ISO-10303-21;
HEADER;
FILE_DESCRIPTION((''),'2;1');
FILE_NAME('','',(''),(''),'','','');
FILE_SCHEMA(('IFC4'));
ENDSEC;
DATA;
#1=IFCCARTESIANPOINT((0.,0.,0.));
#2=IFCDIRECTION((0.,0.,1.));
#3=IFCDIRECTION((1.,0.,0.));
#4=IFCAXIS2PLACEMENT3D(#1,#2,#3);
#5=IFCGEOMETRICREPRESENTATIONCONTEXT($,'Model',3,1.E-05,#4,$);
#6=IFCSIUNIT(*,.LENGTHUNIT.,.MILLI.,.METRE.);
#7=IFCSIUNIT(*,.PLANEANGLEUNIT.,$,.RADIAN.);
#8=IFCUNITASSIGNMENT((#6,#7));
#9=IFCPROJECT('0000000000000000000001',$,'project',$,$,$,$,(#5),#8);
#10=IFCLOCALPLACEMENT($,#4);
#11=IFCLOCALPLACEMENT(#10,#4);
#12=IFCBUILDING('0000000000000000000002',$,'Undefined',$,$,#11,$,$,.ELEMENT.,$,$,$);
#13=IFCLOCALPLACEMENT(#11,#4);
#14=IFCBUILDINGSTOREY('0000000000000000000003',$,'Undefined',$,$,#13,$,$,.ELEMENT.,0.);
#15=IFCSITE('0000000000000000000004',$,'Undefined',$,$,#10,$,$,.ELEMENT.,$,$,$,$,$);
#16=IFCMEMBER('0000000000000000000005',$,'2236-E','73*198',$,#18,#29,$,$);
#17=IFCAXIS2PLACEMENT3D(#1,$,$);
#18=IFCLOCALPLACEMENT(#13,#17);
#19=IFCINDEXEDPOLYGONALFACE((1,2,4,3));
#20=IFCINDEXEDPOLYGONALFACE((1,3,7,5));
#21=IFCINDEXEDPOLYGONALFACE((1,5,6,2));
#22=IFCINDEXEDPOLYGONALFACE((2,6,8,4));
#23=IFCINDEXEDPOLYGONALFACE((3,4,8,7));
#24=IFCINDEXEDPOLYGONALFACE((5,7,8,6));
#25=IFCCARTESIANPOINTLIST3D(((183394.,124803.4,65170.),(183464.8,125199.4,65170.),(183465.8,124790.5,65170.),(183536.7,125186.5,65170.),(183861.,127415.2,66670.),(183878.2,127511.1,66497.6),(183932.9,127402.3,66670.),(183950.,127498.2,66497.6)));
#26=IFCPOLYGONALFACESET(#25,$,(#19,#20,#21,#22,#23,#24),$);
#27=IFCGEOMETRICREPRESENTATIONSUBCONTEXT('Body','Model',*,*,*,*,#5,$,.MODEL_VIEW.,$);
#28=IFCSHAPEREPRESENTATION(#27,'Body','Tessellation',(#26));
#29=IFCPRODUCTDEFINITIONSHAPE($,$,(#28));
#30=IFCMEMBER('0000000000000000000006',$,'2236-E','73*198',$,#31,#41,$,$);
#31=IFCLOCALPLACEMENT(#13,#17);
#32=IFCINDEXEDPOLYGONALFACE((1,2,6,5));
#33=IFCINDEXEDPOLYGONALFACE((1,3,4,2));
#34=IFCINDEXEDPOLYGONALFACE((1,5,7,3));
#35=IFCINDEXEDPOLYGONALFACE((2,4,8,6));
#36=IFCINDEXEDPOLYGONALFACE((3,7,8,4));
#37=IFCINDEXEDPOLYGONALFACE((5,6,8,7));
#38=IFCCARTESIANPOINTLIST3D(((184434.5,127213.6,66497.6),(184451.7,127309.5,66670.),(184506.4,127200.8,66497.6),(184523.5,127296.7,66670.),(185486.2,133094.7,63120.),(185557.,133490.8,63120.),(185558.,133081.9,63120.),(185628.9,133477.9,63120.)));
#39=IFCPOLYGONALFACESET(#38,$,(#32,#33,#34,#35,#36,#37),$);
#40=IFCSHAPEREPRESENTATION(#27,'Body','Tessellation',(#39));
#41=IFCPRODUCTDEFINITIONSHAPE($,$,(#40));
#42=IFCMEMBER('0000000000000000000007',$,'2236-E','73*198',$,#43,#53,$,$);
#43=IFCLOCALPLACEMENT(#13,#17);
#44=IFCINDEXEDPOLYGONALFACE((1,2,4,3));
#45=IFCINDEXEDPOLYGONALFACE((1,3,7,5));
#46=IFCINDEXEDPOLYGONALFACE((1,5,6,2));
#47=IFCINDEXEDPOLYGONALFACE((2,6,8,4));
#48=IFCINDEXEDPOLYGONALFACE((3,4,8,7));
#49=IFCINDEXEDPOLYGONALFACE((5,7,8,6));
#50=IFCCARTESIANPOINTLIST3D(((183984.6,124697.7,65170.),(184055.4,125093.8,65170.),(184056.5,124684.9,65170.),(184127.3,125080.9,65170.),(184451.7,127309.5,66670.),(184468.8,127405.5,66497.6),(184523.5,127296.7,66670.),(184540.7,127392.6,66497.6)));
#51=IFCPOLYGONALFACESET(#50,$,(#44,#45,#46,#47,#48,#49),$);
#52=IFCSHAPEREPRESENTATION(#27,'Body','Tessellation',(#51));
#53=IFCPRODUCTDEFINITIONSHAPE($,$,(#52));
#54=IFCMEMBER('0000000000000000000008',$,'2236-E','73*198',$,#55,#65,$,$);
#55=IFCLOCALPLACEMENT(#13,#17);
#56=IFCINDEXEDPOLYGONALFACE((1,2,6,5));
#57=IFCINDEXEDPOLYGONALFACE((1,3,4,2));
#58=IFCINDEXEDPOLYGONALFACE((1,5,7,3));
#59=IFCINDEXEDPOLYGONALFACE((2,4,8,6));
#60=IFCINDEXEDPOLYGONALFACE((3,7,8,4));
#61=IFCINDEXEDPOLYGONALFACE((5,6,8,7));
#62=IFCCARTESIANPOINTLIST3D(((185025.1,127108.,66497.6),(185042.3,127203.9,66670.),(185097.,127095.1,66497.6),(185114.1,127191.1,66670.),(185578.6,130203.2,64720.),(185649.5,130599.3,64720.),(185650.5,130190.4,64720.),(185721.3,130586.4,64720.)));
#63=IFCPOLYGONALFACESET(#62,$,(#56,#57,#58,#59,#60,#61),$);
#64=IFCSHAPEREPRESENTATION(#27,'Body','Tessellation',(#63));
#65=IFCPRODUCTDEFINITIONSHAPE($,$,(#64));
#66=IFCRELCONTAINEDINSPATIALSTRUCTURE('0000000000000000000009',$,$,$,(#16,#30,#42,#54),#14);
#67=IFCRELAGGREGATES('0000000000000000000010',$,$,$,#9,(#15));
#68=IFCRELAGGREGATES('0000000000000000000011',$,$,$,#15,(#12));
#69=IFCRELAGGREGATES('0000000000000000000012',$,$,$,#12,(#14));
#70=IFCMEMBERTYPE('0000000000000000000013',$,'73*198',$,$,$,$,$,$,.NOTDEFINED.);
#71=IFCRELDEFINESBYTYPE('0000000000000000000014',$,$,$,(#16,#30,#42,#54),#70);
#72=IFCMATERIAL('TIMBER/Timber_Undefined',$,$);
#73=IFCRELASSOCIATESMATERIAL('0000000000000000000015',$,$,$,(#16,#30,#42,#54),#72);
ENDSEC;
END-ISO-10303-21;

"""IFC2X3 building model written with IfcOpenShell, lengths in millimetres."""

from ifc_helpers import new_model, si_unit, frame, origin_with_axes, origin_2d_with_axis, place, context, subcontext, project, spatial, rectangle, extrude, clip, halfspace, material, type_object, element, save


model = new_model("IFC2X3")

# Units and contexts
model_context = context("Model", 3, precision=1e-05, world=origin_with_axes())
body_context = subcontext(model_context, "Body", "Model", "MODEL_VIEW")
ifc_project = project(units=[si_unit("LENGTHUNIT", "METRE", prefix="MILLI"), si_unit("PLANEANGLEUNIT", "RADIAN")], contexts=[model_context])

# Site, building, storey
site_placement = place(None, origin_with_axes())
site = spatial("IfcSite", under=ifc_project, at=site_placement, Name="Undefined", CompositionType="ELEMENT")
building_placement = place(site_placement, origin_with_axes())
building = spatial("IfcBuilding", under=site, at=building_placement, Name="Undefined", CompositionType="ELEMENT")
storey_placement = place(building_placement, origin_with_axes())
storey = spatial("IfcBuildingStorey", under=building, at=storey_placement, Name="Undefined", CompositionType="ELEMENT", Elevation=0.0)

# Shared definitions
ifc_material = material(Name="TIMBER/Timber_Undefined")

# Members
member_type = type_object("IfcMemberType", Name="73*198", PredefinedType="NOTDEFINED")
member_1_placement = place(storey_placement, frame((183905.5, 127456.7, 66583.8), z_axis=(-0.984385, 0.176032, 0.0), x_axis=(-0.153238, -0.85692, -0.492144)))
element("IfcMember", 1, at=member_1_placement, inside=storey, type_object=member_type, material=ifc_material, Name="2236-E", Description="73*198", context=body_context, shape_type="Clipping", body=[
    clip(extrude(rectangle(XDim=198.0, YDim=73.0, at=origin_2d_with_axis()), frame((9448.4, 0.0, 0.0), z_axis=(-1.0, 0.0, 0.0), x_axis=(0.0, -1.0, 0.0)), (0.0, 0.0, 1.0), 9448.5), halfspace(frame((3047.9, 99.0, 36.5), z_axis=(0.492144, -0.870514, 0.0), x_axis=(0.0, 0.0, -1.0)), False)),
])
member_2_placement = place(storey_placement, frame((184479.0, 127255.2, 66583.8), z_axis=(0.984385, -0.176032, 0.0), x_axis=(0.153238, 0.85692, -0.492144)))
element("IfcMember", 2, at=member_2_placement, inside=storey, type_object=member_type, material=ifc_material, Name="2236-E", Description="73*198", context=body_context, shape_type="Clipping", body=[
    clip(extrude(rectangle(XDim=198.0, YDim=73.0, at=origin_2d_with_axis()), frame((9448.4, 0.0, 0.0), z_axis=(-1.0, 0.0, 0.0), x_axis=(0.0, -1.0, 0.0)), (0.0, 0.0, 1.0), 9448.5), halfspace(frame((7213.3, 99.0, 36.5), z_axis=(0.492144, -0.870514, 0.0), x_axis=(0.0, 0.0, -1.0)), False)),
])
member_3_placement = place(storey_placement, frame((184496.2, 127351.1, 66583.8), z_axis=(-0.984385, 0.176032, 0.0), x_axis=(-0.153238, -0.85692, -0.492144)))
element("IfcMember", 3, at=member_3_placement, inside=storey, type_object=member_type, material=ifc_material, Name="2236-E", Description="73*198", context=body_context, shape_type="Clipping", body=[
    clip(extrude(rectangle(XDim=198.0, YDim=73.0, at=origin_2d_with_axis()), frame((9448.4, 0.0, 0.0), z_axis=(-1.0, 0.0, 0.0), x_axis=(0.0, -1.0, 0.0)), (0.0, 0.0, 1.0), 9448.5), halfspace(frame((3047.9, 99.0, 36.5), z_axis=(0.492144, -0.870514, 0.0), x_axis=(0.0, 0.0, -1.0)), False)),
])
member_4_placement = place(storey_placement, frame((185069.6, 127149.5, 66583.8), z_axis=(0.984385, -0.176032, 0.0), x_axis=(0.153238, 0.85692, -0.492144)))
element("IfcMember", 4, at=member_4_placement, inside=storey, type_object=member_type, material=ifc_material, Name="2236-E", Description="73*198", context=body_context, shape_type="Clipping", body=[
    clip(extrude(rectangle(XDim=198.0, YDim=73.0, at=origin_2d_with_axis()), frame((9448.4, 0.0, 0.0), z_axis=(-1.0, 0.0, 0.0), x_axis=(0.0, -1.0, 0.0)), (0.0, 0.0, 1.0), 9448.5), halfspace(frame((6425.9, 1491.8, 36.5), z_axis=(0.492144, -0.870514, 0.0), x_axis=(0.0, 0.0, -1.0)), False)),
])

save(model, "model.ifc")
